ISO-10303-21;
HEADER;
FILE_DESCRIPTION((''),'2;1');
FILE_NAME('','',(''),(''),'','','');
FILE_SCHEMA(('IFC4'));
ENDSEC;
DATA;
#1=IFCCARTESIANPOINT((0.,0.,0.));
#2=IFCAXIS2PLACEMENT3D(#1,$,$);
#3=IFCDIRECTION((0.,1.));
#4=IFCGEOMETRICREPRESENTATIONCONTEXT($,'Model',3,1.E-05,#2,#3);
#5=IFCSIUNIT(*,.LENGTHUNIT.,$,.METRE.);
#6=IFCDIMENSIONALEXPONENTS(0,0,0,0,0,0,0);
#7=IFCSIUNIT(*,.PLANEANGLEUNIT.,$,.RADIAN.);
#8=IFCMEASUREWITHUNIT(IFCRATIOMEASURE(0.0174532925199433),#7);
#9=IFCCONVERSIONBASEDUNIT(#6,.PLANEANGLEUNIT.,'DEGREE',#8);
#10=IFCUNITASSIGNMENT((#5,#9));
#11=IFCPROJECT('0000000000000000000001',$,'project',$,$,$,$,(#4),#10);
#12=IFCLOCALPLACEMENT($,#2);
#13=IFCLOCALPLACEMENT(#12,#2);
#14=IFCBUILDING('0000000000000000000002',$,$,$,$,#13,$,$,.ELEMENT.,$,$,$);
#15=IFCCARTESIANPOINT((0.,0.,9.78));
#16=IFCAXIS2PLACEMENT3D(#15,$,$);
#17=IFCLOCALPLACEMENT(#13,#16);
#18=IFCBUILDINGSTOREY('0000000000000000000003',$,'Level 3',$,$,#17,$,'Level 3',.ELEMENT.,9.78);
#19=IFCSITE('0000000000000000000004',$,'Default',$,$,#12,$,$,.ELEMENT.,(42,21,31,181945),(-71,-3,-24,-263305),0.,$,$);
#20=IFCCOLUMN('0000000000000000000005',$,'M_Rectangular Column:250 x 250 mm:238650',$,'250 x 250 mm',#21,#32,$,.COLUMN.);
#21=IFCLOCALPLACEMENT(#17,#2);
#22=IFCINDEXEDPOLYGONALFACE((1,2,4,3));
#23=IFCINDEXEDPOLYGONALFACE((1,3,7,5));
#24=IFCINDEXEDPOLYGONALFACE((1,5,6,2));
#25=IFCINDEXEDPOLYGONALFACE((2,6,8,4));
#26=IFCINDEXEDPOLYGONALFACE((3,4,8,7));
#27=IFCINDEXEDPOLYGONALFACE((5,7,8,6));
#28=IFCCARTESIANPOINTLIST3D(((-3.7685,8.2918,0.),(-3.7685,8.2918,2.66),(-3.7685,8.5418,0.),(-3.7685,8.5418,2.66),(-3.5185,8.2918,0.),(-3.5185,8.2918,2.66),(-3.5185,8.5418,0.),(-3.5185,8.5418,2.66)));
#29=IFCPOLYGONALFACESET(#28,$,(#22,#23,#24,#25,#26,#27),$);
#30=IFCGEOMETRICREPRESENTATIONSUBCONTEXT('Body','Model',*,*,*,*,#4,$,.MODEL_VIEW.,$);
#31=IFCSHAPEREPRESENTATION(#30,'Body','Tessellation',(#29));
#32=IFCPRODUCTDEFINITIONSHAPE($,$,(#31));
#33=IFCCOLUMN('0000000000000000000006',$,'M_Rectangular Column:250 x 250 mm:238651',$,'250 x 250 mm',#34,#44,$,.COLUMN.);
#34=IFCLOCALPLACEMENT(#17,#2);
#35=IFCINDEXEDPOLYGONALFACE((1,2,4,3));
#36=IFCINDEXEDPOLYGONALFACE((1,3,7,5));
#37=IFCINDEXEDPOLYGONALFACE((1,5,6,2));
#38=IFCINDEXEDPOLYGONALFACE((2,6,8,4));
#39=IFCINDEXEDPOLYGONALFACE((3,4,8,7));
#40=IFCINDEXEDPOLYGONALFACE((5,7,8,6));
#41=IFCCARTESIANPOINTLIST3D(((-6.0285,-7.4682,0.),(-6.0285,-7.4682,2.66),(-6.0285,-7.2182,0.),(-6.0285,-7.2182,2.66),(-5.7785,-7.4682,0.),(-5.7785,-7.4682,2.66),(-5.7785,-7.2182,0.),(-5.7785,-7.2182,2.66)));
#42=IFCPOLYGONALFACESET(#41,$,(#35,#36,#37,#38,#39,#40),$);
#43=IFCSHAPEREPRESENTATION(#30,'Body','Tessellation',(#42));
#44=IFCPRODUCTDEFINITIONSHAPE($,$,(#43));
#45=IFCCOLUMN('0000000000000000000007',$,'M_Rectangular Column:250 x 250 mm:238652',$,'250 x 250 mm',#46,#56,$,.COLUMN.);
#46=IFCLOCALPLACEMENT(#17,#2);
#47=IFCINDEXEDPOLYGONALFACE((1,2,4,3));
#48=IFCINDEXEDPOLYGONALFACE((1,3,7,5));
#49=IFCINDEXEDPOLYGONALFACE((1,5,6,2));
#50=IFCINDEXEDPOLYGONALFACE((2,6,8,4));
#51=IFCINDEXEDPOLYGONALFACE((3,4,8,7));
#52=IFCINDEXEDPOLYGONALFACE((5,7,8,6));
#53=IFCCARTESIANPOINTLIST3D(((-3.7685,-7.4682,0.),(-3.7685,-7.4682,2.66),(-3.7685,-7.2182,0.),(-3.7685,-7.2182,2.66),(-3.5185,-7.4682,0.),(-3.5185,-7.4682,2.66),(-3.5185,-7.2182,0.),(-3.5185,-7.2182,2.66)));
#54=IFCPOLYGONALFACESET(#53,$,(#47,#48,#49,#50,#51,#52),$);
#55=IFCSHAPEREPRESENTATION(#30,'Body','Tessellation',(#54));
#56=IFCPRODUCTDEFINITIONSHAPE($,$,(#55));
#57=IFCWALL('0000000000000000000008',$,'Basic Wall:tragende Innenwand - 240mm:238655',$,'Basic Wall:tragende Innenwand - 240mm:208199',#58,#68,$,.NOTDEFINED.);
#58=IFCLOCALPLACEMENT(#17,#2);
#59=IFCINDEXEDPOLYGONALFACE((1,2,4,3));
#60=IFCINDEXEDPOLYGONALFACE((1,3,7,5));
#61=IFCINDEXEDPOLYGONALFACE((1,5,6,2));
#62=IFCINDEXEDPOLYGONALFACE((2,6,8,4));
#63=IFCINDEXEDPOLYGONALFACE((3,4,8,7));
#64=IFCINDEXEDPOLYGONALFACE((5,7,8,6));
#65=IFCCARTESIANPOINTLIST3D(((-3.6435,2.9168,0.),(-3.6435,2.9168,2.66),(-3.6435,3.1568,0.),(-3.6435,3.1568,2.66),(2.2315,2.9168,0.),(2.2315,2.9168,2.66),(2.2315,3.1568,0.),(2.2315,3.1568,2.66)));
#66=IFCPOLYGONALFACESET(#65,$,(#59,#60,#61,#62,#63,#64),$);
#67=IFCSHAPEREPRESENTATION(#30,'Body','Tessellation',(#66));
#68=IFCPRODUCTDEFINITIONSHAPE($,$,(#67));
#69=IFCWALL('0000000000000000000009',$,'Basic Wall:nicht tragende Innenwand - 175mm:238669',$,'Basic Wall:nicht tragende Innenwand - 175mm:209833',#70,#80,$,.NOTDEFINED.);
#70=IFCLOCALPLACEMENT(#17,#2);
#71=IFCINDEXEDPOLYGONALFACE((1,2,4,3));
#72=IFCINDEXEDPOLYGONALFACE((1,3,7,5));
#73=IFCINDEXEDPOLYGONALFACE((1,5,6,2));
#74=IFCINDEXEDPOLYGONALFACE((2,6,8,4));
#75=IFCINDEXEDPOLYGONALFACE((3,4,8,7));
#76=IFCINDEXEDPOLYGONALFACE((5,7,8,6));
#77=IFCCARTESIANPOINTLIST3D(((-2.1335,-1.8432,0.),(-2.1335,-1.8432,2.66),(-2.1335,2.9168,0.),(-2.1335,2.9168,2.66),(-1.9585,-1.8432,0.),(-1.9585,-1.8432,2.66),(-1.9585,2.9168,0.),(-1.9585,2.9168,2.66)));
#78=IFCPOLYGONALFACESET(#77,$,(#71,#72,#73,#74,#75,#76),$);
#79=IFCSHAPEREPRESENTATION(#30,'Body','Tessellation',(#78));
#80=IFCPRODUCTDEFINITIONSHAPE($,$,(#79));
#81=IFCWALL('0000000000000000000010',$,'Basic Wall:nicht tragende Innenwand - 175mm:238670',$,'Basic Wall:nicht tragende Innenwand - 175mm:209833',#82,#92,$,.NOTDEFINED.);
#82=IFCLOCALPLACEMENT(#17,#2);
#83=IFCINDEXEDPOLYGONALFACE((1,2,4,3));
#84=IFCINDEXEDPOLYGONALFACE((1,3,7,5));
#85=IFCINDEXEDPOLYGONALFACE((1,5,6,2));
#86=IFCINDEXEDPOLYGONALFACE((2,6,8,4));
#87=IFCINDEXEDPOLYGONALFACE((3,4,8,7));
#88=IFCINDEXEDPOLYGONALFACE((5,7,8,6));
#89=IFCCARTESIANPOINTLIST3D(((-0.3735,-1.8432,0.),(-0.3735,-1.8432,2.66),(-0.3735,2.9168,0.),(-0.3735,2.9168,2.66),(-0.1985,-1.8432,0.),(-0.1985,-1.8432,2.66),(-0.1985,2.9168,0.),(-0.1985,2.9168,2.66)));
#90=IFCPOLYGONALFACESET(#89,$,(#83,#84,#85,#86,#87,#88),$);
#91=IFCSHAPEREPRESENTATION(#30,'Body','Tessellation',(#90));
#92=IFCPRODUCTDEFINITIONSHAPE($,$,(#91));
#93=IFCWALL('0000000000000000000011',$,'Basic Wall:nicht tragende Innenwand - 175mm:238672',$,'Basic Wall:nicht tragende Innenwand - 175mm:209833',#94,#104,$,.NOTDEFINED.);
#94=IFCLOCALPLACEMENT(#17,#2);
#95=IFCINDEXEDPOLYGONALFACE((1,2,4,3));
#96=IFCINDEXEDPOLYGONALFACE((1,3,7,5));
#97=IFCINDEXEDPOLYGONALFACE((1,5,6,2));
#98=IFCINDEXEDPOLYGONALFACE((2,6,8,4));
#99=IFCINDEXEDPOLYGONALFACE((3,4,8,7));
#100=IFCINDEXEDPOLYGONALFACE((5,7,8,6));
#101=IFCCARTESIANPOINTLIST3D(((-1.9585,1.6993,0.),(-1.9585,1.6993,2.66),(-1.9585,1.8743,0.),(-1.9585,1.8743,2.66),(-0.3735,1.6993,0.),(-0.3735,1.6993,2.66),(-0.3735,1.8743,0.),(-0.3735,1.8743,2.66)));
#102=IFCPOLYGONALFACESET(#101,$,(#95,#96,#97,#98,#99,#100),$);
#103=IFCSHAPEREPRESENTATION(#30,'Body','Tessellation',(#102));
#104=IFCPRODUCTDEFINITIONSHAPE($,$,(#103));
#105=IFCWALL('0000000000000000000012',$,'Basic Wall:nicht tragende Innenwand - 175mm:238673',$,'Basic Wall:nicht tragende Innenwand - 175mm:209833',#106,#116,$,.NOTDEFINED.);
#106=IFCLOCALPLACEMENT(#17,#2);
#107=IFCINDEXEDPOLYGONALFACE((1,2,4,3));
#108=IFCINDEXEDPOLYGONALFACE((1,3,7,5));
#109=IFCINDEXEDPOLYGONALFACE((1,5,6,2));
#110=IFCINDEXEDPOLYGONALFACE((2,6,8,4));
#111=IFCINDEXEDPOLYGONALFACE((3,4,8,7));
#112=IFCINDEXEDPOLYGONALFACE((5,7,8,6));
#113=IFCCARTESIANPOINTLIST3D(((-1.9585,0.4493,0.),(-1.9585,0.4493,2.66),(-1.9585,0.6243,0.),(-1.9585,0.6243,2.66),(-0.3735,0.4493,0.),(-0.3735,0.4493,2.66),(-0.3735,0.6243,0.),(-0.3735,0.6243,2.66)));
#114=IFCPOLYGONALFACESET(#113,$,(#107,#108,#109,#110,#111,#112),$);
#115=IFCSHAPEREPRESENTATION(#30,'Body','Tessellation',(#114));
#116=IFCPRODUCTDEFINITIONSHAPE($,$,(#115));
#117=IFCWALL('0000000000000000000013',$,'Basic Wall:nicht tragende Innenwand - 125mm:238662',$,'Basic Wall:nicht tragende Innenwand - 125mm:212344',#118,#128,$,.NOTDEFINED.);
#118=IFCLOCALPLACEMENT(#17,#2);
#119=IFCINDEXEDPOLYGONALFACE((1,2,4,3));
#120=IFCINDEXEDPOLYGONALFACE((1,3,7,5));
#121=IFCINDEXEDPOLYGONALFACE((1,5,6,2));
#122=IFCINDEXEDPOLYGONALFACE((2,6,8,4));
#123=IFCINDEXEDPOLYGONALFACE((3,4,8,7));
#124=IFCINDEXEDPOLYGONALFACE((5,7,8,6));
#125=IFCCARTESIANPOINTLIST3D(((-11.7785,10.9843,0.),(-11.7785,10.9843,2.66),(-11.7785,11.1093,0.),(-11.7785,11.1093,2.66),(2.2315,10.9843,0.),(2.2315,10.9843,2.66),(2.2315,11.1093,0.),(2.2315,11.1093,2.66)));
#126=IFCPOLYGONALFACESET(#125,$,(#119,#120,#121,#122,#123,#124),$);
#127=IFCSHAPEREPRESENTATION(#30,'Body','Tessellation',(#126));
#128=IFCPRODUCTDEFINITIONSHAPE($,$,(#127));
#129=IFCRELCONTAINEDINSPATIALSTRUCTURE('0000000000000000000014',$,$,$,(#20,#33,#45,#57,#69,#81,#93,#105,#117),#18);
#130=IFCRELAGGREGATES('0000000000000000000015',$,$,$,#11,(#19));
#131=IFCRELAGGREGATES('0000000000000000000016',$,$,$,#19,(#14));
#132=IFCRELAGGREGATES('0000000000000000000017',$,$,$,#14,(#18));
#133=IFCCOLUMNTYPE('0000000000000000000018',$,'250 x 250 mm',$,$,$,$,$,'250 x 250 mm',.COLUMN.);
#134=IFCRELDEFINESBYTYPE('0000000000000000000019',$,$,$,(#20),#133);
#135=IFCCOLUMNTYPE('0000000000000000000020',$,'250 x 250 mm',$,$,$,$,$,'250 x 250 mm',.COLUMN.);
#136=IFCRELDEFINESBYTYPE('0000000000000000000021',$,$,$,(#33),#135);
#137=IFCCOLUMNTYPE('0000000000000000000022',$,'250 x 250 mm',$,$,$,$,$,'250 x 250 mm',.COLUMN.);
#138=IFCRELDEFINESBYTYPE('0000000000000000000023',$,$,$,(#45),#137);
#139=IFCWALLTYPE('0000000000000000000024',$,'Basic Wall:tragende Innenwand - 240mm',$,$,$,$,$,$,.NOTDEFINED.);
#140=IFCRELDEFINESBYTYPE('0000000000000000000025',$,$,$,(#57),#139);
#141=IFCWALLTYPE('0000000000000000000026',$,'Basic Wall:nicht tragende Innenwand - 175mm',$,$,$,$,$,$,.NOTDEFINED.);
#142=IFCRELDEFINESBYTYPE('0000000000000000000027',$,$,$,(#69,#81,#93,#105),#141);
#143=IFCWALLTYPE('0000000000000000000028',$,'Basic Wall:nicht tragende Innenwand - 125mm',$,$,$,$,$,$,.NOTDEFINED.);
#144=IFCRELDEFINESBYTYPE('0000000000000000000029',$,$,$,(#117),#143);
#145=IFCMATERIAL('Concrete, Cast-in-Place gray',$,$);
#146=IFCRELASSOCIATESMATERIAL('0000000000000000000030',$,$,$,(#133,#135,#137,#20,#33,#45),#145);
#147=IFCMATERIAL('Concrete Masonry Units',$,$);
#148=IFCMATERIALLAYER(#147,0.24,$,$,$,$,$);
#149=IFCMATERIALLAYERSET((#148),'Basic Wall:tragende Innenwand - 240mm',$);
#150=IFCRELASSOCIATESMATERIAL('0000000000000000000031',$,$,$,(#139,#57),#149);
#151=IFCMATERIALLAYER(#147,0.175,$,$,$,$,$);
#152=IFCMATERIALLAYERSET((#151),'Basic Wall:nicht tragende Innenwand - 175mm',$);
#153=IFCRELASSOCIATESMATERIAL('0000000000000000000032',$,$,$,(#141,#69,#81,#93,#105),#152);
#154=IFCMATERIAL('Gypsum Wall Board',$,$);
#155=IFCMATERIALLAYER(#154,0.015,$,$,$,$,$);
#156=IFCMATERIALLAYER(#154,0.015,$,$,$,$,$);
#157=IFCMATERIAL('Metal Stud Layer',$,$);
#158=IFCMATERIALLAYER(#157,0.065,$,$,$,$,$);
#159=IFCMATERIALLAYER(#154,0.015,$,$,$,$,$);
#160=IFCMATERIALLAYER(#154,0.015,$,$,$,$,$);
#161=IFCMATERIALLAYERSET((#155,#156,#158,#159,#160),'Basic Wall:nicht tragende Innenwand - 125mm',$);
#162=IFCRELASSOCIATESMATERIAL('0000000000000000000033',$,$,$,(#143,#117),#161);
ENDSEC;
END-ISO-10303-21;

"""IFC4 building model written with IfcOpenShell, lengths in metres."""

from ifc_helpers import new_model, entity, si_unit, converted_unit, direction, frame, frame_2d, origin, place, context, subcontext, project, spatial, rectangle, extrude, source, transform, mapped, material, layer, layer_set, layer_usage, material_profile, profile_set, profile_usage, type_object, type_shapes, element, save


model = new_model("IFC4")

# Units and contexts
model_context = context("Model", 3, precision=1e-05, world=origin(), true_north=direction((0.0, 1.0)))
body_context = subcontext(model_context, "Body", "Model", "MODEL_VIEW")
ifc_project = project(units=[si_unit("LENGTHUNIT", "METRE"), converted_unit("PLANEANGLEUNIT", "DEGREE", entity("IfcRatioMeasure", 0.0174532925199433), si_unit("PLANEANGLEUNIT", "RADIAN"), dimensions=[0, 0, 0, 0, 0, 0, 0])], contexts=[model_context])

# Site, building, storey
site_placement = place(None, origin())
site = spatial("IfcSite", under=ifc_project, at=site_placement, Name="Default", CompositionType="ELEMENT", RefLatitude=(42, 21, 31, 181945), RefLongitude=(-71, -3, -24, -263305), RefElevation=0.0)
building_placement = place(site_placement, origin())
building = spatial("IfcBuilding", under=site, at=building_placement, CompositionType="ELEMENT")
storey_placement = place(building_placement, frame((0.0, 0.0, 9.78)))
storey = spatial("IfcBuildingStorey", under=building, at=storey_placement, Name="Level 3", LongName="Level 3", CompositionType="ELEMENT", Elevation=9.78)

# Columns
ifc_material_1 = material(Name="Concrete, Cast-in-Place gray")
ifc_material_profile = material_profile(ifc_material_1, rectangle(XDim=0.25, YDim=0.25, at=frame_2d((0.0, 0.0), x_axis=(1.0, 0.0))))
ifc_profile_set = profile_set([ifc_material_profile], Name="250 x 250 mm")
ifc_profile_usage_1 = profile_usage(ifc_profile_set)
column_type_1 = type_object("IfcColumnType", Name="250 x 250 mm", ElementType="250 x 250 mm", PredefinedType="COLUMN", material=ifc_profile_set)
shared_shape_1 = source(origin(), body_context, "Body", "SweptSolid", [
    extrude(rectangle(XDim=0.25, YDim=0.25, at=frame_2d((0.0, 0.0), x_axis=(1.0, 0.0))), frame((-3.6435, 8.4168, 9.78), z_axis=(0.0, 0.0, 1.0), x_axis=(0.0, -1.0, 0.0)), (0.0, 0.0, 1.0), 2.66),
])
type_shapes(column_type_1, [shared_shape_1])
column_1_placement = place(storey_placement, frame((0.0, 0.0, -9.78)))
element("IfcColumn", 1, at=column_1_placement, inside=storey, type_object=column_type_1, material=ifc_profile_usage_1, Name="M_Rectangular Column:250 x 250 mm:238650", ObjectType="250 x 250 mm", PredefinedType="COLUMN", context=body_context, shape_type="MappedRepresentation", body=[
    mapped(shared_shape_1, transform((0.0, 0.0, 0.0), scale=1.0)),
])
ifc_profile_usage_2 = profile_usage(ifc_profile_set)
column_type_2 = type_object("IfcColumnType", Name="250 x 250 mm", ElementType="250 x 250 mm", PredefinedType="COLUMN", material=ifc_profile_set)
shared_shape_2 = source(origin(), body_context, "Body", "SweptSolid", [
    extrude(rectangle(XDim=0.25, YDim=0.25, at=frame_2d((0.0, 0.0), x_axis=(1.0, 0.0))), frame((-5.9035, -7.3432, 9.78), z_axis=(0.0, 0.0, 1.0), x_axis=(0.0, -1.0, 0.0)), (0.0, 0.0, 1.0), 2.66),
])
type_shapes(column_type_2, [shared_shape_2])
column_2_placement = place(storey_placement, frame((0.0, 0.0, -9.78)))
element("IfcColumn", 2, at=column_2_placement, inside=storey, type_object=column_type_2, material=ifc_profile_usage_2, Name="M_Rectangular Column:250 x 250 mm:238651", ObjectType="250 x 250 mm", PredefinedType="COLUMN", context=body_context, shape_type="MappedRepresentation", body=[
    mapped(shared_shape_2, transform((0.0, 0.0, 0.0), scale=1.0)),
])
ifc_profile_usage_3 = profile_usage(ifc_profile_set)
column_type_3 = type_object("IfcColumnType", Name="250 x 250 mm", ElementType="250 x 250 mm", PredefinedType="COLUMN", material=ifc_profile_set)
shared_shape_3 = source(origin(), body_context, "Body", "SweptSolid", [
    extrude(rectangle(XDim=0.25, YDim=0.25, at=frame_2d((0.0, 0.0), x_axis=(1.0, 0.0))), frame((-3.6435, -7.3432, 9.78), z_axis=(0.0, 0.0, 1.0), x_axis=(0.0, -1.0, 0.0)), (0.0, 0.0, 1.0), 2.66),
])
type_shapes(column_type_3, [shared_shape_3])
column_3_placement = place(storey_placement, frame((0.0, 0.0, -9.78)))
element("IfcColumn", 3, at=column_3_placement, inside=storey, type_object=column_type_3, material=ifc_profile_usage_3, Name="M_Rectangular Column:250 x 250 mm:238652", ObjectType="250 x 250 mm", PredefinedType="COLUMN", context=body_context, shape_type="MappedRepresentation", body=[
    mapped(shared_shape_3, transform((0.0, 0.0, 0.0), scale=1.0)),
])

# Walls
ifc_material_2 = material(Name="Concrete Masonry Units")
ifc_layer_1 = layer(ifc_material_2, 0.24)
ifc_layer_set_1 = layer_set([ifc_layer_1], Name="Basic Wall:tragende Innenwand - 240mm")
ifc_layer_usage_1 = layer_usage(ifc_layer_set_1, "AXIS2", "NEGATIVE", 0.12)
wall_type_1 = type_object("IfcWallType", Name="Basic Wall:tragende Innenwand - 240mm", PredefinedType="NOTDEFINED", material=ifc_layer_set_1)
wall_1_placement = place(storey_placement, frame((2.2315, 3.0368, 0.0), z_axis=(0.0, 0.0, 1.0), x_axis=(-1.0, 0.0, 0.0)))
element("IfcWall", 4, at=wall_1_placement, inside=storey, type_object=wall_type_1, material=ifc_layer_usage_1, Name="Basic Wall:tragende Innenwand - 240mm:238655", ObjectType="Basic Wall:tragende Innenwand - 240mm:208199", PredefinedType="NOTDEFINED", context=body_context, shape_type="SweptSolid", body=[
    extrude(rectangle(XDim=5.875, YDim=0.24, at=frame_2d((2.9375, 0.0), x_axis=(-1.0, 0.0))), origin(), (0.0, 0.0, 1.0), 2.66),
])
ifc_layer_2 = layer(ifc_material_2, 0.175)
ifc_layer_set_2 = layer_set([ifc_layer_2], Name="Basic Wall:nicht tragende Innenwand - 175mm")
ifc_layer_usage_2 = layer_usage(ifc_layer_set_2, "AXIS2", "NEGATIVE", 0.0875)
wall_type_2 = type_object("IfcWallType", Name="Basic Wall:nicht tragende Innenwand - 175mm", PredefinedType="NOTDEFINED", material=ifc_layer_set_2)
wall_2_placement = place(storey_placement, frame((-2.046, 2.9168, 0.0), z_axis=(0.0, 0.0, 1.0), x_axis=(0.0, -1.0, 0.0)))
element("IfcWall", 5, at=wall_2_placement, inside=storey, type_object=wall_type_2, material=ifc_layer_usage_2, Name="Basic Wall:nicht tragende Innenwand - 175mm:238669", ObjectType="Basic Wall:nicht tragende Innenwand - 175mm:209833", PredefinedType="NOTDEFINED", context=body_context, shape_type="SweptSolid", body=[
    extrude(rectangle(XDim=4.76, YDim=0.175, at=frame_2d((2.38, 0.0), x_axis=(-1.0, 0.0))), origin(), (0.0, 0.0, 1.0), 2.66),
])
ifc_layer_usage_3 = layer_usage(ifc_layer_set_2, "AXIS2", "NEGATIVE", 0.0875)
wall_3_placement = place(storey_placement, frame((-0.286, 2.9168, 0.0), z_axis=(0.0, 0.0, 1.0), x_axis=(0.0, -1.0, 0.0)))
element("IfcWall", 6, at=wall_3_placement, inside=storey, type_object=wall_type_2, material=ifc_layer_usage_3, Name="Basic Wall:nicht tragende Innenwand - 175mm:238670", ObjectType="Basic Wall:nicht tragende Innenwand - 175mm:209833", PredefinedType="NOTDEFINED", context=body_context, shape_type="SweptSolid", body=[
    extrude(rectangle(XDim=4.76, YDim=0.175, at=frame_2d((2.38, 0.0), x_axis=(-1.0, 0.0))), origin(), (0.0, 0.0, 1.0), 2.66),
])
ifc_layer_usage_4 = layer_usage(ifc_layer_set_2, "AXIS2", "POSITIVE", -0.0875)
wall_4_placement = place(storey_placement, frame((-1.9585, 1.7868, 0.0)))
element("IfcWall", 7, at=wall_4_placement, inside=storey, type_object=wall_type_2, material=ifc_layer_usage_4, Name="Basic Wall:nicht tragende Innenwand - 175mm:238672", ObjectType="Basic Wall:nicht tragende Innenwand - 175mm:209833", PredefinedType="NOTDEFINED", context=body_context, shape_type="SweptSolid", body=[
    extrude(rectangle(XDim=1.585, YDim=0.175, at=frame_2d((0.7925, 0.0), x_axis=(-1.0, 0.0))), origin(), (0.0, 0.0, 1.0), 2.66),
])
ifc_layer_usage_5 = layer_usage(ifc_layer_set_2, "AXIS2", "POSITIVE", -0.0875)
wall_5_placement = place(storey_placement, frame((-1.9585, 0.5368, 0.0)))
element("IfcWall", 8, at=wall_5_placement, inside=storey, type_object=wall_type_2, material=ifc_layer_usage_5, Name="Basic Wall:nicht tragende Innenwand - 175mm:238673", ObjectType="Basic Wall:nicht tragende Innenwand - 175mm:209833", PredefinedType="NOTDEFINED", context=body_context, shape_type="SweptSolid", body=[
    extrude(rectangle(XDim=1.585, YDim=0.175, at=frame_2d((0.7925, 0.0), x_axis=(-1.0, 0.0))), origin(), (0.0, 0.0, 1.0), 2.66),
])
ifc_material_3 = material(Name="Gypsum Wall Board")
ifc_layer_3 = layer(ifc_material_3, 0.015)
ifc_layer_4 = layer(ifc_material_3, 0.015)
ifc_material_4 = material(Name="Metal Stud Layer")
ifc_layer_5 = layer(ifc_material_4, 0.065)
ifc_layer_6 = layer(ifc_material_3, 0.015)
ifc_layer_7 = layer(ifc_material_3, 0.015)
ifc_layer_set_3 = layer_set([ifc_layer_3, ifc_layer_4, ifc_layer_5, ifc_layer_6, ifc_layer_7], Name="Basic Wall:nicht tragende Innenwand - 125mm")
ifc_layer_usage_6 = layer_usage(ifc_layer_set_3, "AXIS2", "NEGATIVE", 0.0625)
wall_type_3 = type_object("IfcWallType", Name="Basic Wall:nicht tragende Innenwand - 125mm", PredefinedType="NOTDEFINED", material=ifc_layer_set_3)
wall_6_placement = place(storey_placement, frame((2.2315, 11.0468, 0.0), z_axis=(0.0, 0.0, 1.0), x_axis=(-1.0, 0.0, 0.0)))
element("IfcWall", 9, at=wall_6_placement, inside=storey, type_object=wall_type_3, material=ifc_layer_usage_6, Name="Basic Wall:nicht tragende Innenwand - 125mm:238662", ObjectType="Basic Wall:nicht tragende Innenwand - 125mm:212344", PredefinedType="NOTDEFINED", context=body_context, shape_type="SweptSolid", body=[
    extrude(rectangle(XDim=14.01, YDim=0.125, at=frame_2d((7.005, 0.0), x_axis=(-1.0, 0.0))), origin(), (0.0, 0.0, 1.0), 2.66),
])

save(model, "model.ifc")
